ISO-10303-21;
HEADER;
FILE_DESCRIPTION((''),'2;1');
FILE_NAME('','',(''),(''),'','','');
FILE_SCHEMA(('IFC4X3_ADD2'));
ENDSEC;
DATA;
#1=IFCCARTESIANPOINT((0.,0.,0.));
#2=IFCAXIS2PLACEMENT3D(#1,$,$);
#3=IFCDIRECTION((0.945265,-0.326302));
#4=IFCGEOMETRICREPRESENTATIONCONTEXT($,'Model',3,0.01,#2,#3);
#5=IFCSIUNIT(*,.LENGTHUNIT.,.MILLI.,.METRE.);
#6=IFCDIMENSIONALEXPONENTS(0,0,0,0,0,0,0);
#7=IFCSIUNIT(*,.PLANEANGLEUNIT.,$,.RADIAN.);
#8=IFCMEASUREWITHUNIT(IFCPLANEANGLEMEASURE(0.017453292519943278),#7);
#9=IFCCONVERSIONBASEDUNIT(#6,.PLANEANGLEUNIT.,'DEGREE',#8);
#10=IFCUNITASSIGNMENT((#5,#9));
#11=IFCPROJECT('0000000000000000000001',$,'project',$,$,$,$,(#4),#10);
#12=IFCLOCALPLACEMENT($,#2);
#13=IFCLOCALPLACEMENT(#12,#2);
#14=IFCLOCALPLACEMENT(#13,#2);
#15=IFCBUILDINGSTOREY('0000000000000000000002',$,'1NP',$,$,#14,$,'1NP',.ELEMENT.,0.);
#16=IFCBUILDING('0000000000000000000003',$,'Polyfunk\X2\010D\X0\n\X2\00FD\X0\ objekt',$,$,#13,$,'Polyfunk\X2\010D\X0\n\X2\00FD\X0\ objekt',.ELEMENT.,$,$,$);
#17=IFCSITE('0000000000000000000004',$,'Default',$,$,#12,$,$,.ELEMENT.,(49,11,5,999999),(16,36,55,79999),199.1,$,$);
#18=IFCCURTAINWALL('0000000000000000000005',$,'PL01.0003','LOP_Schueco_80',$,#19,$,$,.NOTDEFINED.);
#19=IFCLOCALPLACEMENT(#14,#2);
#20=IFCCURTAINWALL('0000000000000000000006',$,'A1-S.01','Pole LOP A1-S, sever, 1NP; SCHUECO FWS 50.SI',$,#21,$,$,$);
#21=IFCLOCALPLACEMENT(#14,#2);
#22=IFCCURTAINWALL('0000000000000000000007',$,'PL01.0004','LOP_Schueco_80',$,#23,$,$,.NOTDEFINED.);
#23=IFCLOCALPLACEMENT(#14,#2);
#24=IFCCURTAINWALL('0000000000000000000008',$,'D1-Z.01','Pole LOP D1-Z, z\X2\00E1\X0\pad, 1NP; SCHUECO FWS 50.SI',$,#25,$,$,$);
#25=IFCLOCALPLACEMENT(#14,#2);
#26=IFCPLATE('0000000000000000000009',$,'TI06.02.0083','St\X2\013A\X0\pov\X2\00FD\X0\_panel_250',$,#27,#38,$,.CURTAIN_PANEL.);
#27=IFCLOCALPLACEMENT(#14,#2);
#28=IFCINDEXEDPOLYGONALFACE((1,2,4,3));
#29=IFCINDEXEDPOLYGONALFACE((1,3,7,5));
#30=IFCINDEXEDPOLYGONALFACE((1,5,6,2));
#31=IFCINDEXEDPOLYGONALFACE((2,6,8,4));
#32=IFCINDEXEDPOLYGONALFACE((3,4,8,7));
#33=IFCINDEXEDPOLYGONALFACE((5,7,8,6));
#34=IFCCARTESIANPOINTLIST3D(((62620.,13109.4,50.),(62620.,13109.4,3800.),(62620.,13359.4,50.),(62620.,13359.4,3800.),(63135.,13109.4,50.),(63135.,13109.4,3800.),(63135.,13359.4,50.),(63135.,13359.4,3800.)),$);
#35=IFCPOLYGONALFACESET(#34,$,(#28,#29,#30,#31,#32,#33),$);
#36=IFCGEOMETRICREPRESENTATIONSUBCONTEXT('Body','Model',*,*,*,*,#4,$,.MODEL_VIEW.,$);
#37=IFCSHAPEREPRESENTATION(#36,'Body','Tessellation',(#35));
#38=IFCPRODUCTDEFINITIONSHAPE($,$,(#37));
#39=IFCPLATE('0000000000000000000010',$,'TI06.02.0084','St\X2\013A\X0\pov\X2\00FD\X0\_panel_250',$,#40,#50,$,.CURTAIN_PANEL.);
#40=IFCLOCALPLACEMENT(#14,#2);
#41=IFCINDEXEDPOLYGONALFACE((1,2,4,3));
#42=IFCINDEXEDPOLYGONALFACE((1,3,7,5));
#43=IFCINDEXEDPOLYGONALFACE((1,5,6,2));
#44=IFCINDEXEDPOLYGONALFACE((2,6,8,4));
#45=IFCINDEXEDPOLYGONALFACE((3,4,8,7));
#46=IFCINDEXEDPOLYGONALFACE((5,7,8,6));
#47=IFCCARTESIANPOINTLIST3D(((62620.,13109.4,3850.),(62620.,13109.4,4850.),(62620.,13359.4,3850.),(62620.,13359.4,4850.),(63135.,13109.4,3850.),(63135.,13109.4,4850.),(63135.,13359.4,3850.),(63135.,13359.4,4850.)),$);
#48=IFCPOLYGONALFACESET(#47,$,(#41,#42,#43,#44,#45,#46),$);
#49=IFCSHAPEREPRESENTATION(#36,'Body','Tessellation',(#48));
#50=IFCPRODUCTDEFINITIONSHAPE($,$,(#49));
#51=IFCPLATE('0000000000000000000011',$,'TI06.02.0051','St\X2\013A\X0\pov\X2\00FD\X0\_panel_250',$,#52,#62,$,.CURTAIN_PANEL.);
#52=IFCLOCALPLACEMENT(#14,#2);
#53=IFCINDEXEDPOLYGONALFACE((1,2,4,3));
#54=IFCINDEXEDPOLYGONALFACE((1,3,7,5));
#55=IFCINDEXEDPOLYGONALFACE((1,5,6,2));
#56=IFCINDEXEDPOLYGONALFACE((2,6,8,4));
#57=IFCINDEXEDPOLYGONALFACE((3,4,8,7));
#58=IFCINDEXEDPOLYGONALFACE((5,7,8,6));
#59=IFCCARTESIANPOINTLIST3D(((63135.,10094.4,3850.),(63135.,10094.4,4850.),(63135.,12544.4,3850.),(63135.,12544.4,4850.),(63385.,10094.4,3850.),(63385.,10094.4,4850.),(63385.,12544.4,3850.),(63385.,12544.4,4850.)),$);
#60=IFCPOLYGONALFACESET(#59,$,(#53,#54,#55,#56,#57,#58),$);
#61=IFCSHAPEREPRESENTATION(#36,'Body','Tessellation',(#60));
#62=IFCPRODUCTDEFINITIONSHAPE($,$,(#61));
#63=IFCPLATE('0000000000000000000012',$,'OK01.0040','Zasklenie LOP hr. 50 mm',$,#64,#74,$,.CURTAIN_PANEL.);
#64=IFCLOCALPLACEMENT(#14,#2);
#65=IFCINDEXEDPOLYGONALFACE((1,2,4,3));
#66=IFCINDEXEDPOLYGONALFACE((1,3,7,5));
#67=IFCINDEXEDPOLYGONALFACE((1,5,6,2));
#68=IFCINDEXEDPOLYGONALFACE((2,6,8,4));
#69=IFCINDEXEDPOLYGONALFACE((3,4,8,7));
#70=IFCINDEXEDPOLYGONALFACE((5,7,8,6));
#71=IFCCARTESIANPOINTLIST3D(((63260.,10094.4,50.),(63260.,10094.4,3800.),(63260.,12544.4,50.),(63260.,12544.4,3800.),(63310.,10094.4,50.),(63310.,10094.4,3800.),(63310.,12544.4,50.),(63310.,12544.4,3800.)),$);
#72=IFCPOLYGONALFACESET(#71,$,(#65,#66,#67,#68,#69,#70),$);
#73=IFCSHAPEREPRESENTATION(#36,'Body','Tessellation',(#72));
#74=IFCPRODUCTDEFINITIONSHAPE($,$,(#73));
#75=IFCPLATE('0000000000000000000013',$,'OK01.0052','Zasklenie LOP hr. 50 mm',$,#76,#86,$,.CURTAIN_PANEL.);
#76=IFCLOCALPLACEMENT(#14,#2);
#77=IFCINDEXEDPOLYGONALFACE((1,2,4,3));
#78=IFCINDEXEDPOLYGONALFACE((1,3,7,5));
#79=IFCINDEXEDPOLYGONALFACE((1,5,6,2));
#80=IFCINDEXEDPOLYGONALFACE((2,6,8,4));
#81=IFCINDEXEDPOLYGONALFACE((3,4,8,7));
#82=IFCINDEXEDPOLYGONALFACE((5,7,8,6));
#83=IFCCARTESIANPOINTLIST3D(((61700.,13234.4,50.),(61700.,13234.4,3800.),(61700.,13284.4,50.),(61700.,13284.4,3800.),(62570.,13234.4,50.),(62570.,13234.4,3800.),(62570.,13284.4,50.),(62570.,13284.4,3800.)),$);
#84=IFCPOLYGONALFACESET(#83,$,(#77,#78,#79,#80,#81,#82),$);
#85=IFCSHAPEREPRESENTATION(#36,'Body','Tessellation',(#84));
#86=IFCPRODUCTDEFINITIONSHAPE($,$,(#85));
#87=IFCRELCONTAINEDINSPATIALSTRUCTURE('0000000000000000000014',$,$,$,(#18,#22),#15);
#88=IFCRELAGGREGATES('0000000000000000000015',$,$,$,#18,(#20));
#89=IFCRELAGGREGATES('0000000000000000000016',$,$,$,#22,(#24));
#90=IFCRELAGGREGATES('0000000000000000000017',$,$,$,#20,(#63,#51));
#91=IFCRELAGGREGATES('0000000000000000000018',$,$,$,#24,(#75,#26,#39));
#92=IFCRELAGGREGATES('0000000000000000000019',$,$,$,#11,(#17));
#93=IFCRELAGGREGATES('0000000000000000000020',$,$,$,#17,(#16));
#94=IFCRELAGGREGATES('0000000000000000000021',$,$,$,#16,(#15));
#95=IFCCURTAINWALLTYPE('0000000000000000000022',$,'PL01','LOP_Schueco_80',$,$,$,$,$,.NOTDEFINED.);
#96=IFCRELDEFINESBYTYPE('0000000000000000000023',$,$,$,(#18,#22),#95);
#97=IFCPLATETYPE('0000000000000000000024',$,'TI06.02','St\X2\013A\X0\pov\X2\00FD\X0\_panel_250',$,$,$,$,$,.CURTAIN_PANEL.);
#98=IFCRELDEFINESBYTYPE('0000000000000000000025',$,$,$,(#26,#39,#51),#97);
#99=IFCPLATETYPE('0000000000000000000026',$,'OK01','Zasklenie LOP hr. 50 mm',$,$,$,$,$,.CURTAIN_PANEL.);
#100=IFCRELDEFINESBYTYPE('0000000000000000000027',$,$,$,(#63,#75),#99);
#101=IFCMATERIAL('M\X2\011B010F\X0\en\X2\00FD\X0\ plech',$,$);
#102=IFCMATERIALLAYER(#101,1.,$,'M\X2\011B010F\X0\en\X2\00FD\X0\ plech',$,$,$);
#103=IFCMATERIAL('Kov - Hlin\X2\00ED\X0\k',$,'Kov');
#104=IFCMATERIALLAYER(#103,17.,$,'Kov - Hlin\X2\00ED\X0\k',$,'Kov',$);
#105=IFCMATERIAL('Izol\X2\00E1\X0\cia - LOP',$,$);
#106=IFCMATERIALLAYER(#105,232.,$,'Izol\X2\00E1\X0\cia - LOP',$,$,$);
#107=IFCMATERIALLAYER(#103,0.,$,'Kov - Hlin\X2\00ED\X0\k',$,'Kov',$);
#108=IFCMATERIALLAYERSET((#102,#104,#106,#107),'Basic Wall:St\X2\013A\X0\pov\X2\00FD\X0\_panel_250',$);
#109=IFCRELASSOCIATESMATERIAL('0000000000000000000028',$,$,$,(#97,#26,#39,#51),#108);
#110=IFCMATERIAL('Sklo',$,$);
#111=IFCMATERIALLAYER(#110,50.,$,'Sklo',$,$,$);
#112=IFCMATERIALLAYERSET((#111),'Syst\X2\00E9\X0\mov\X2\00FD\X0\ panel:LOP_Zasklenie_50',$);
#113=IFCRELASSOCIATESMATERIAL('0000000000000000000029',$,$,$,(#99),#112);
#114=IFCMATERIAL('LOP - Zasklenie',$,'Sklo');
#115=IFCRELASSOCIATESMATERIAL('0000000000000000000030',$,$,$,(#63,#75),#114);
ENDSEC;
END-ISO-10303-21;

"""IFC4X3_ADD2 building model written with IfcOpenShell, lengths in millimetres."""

from ifc_helpers import new_model, entity, si_unit, converted_unit, direction, frame, frame_2d, origin, place, context, subcontext, project, spatial, rectangle, extrude, source, transform, mapped, material, layer, layer_set, layer_usage, type_object, type_shapes, element, aggregate, save


model = new_model("IFC4X3_ADD2")

# Units and contexts
model_context = context("Model", 3, precision=0.01, world=origin(), true_north=direction((0.945265, -0.326302)))
body_context = subcontext(model_context, "Body", "Model", "MODEL_VIEW")
ifc_project = project(units=[si_unit("LENGTHUNIT", "METRE", prefix="MILLI"), converted_unit("PLANEANGLEUNIT", "DEGREE", entity("IfcPlaneAngleMeasure", 0.017453292519943278), si_unit("PLANEANGLEUNIT", "RADIAN"), dimensions=[0, 0, 0, 0, 0, 0, 0])], contexts=[model_context])

# Site, building, storey
site_placement = place(None, origin())
site = spatial("IfcSite", under=ifc_project, at=site_placement, Name="Default", CompositionType="ELEMENT", RefLatitude=(49, 11, 5, 999999), RefLongitude=(16, 36, 55, 79999), RefElevation=199.1)
building_placement = place(site_placement, origin())
building = spatial("IfcBuilding", under=site, at=building_placement, Name="Polyfunkčný objekt", LongName="Polyfunkčný objekt", CompositionType="ELEMENT")
storey_placement = place(building_placement, origin())
storey = spatial("IfcBuildingStorey", under=building, at=storey_placement, Name="1NP", LongName="1NP", CompositionType="ELEMENT", Elevation=0.0)

# Curtain walls
curtain_wall_type = type_object("IfcCurtainWallType", Name="PL01", Description="LOP_Schueco_80", PredefinedType="NOTDEFINED")
curtain_wall_1_placement = place(storey_placement, origin())
curtain_wall_1 = element("IfcCurtainWall", 1, at=curtain_wall_1_placement, inside=storey, type_object=curtain_wall_type, Name="PL01.0003", Description="LOP_Schueco_80", PredefinedType="NOTDEFINED")
curtain_wall_2 = element("IfcCurtainWall", 2, Name="A1-S.01", Description="Pole LOP A1-S, sever, 1NP; SCHUECO FWS 50.SI")
aggregate(curtain_wall_1, [curtain_wall_2])
curtain_wall_3_placement = place(storey_placement, origin())
curtain_wall_3 = element("IfcCurtainWall", 3, at=curtain_wall_3_placement, inside=storey, type_object=curtain_wall_type, Name="PL01.0004", Description="LOP_Schueco_80", PredefinedType="NOTDEFINED")
curtain_wall_4 = element("IfcCurtainWall", 4, Name="D1-Z.01", Description="Pole LOP D1-Z, západ, 1NP; SCHUECO FWS 50.SI")
aggregate(curtain_wall_3, [curtain_wall_4])

# Plates
ifc_material_1 = material(Name="Měďený plech")
ifc_layer_1 = layer(ifc_material_1, 1.0, Name="Měďený plech")
ifc_material_2 = material(Name="Kov - Hliník", Category="Kov")
ifc_layer_2 = layer(ifc_material_2, 17.0, Name="Kov - Hliník", Category="Kov")
ifc_material_3 = material(Name="Izolácia - LOP")
ifc_layer_3 = layer(ifc_material_3, 232.0, Name="Izolácia - LOP")
ifc_layer_4 = layer(ifc_material_2, 0.0, Name="Kov - Hliník", Category="Kov")
ifc_layer_set_1 = layer_set([ifc_layer_1, ifc_layer_2, ifc_layer_3, ifc_layer_4], Name="Basic Wall:Stĺpový_panel_250")
ifc_layer_usage_1 = layer_usage(ifc_layer_set_1, "AXIS2", "NEGATIVE", 125.0)
plate_type_1 = type_object("IfcPlateType", Name="TI06.02", Description="Stĺpový_panel_250", PredefinedType="CURTAIN_PANEL", material=ifc_layer_set_1)
plate_1_placement = place(storey_placement, frame((62620.0, 13234.4, 50.0)))
plate_1 = element("IfcPlate", 5, at=plate_1_placement, type_object=plate_type_1, material=ifc_layer_usage_1, Name="TI06.02.0083", Description="Stĺpový_panel_250", PredefinedType="CURTAIN_PANEL", context=body_context, shape_type="SweptSolid", body=[
    extrude(rectangle(XDim=250.0, YDim=515.0, at=frame_2d((0.0, 0.0), x_axis=(1.0, 0.0))), frame((257.5, 0.0, 0.0), z_axis=(0.0, 0.0, 1.0), x_axis=(0.0, 1.0, 0.0)), (0.0, 0.0, 1.0), 3750.0),
])
ifc_layer_usage_2 = layer_usage(ifc_layer_set_1, "AXIS2", "NEGATIVE", 125.0)
plate_2_placement = place(storey_placement, frame((62620.0, 13234.4, 3850.0)))
plate_2 = element("IfcPlate", 6, at=plate_2_placement, type_object=plate_type_1, material=ifc_layer_usage_2, Name="TI06.02.0084", Description="Stĺpový_panel_250", PredefinedType="CURTAIN_PANEL", context=body_context, shape_type="SweptSolid", body=[
    extrude(rectangle(XDim=250.0, YDim=515.0, at=frame_2d((0.0, 0.0), x_axis=(1.0, 0.0))), frame((257.5, 0.0, 0.0), z_axis=(0.0, 0.0, 1.0), x_axis=(0.0, 1.0, 0.0)), (0.0, 0.0, 1.0), 1000.0),
])
ifc_layer_usage_3 = layer_usage(ifc_layer_set_1, "AXIS2", "NEGATIVE", 125.0)
plate_3_placement = place(storey_placement, frame((63260.0, 12544.4, 3850.0), z_axis=(0.0, 0.0, 1.0), x_axis=(0.0, -1.0, 0.0)))
plate_3 = element("IfcPlate", 7, at=plate_3_placement, type_object=plate_type_1, material=ifc_layer_usage_3, Name="TI06.02.0051", Description="Stĺpový_panel_250", PredefinedType="CURTAIN_PANEL", context=body_context, shape_type="SweptSolid", body=[
    extrude(rectangle(XDim=250.0, YDim=2450.0, at=frame_2d((0.0, 0.0), x_axis=(1.0, 0.0))), frame((1225.0, 0.0, 0.0), z_axis=(0.0, 0.0, 1.0), x_axis=(0.0, 1.0, 0.0)), (0.0, 0.0, 1.0), 1000.0),
])
ifc_material_4 = material(Name="LOP - Zasklenie", Category="Sklo")
ifc_material_5 = material(Name="Sklo")
ifc_layer_5 = layer(ifc_material_5, 50.0, Name="Sklo")
ifc_layer_set_2 = layer_set([ifc_layer_5], Name="Systémový panel:LOP_Zasklenie_50")
plate_type_2 = type_object("IfcPlateType", Name="OK01", Description="Zasklenie LOP hr. 50 mm", PredefinedType="CURTAIN_PANEL", material=ifc_layer_set_2)
shared_shape_1 = source(origin(), body_context, "Body", "SweptSolid", [
    extrude(rectangle(XDim=3750.0, YDim=2450.0, at=frame_2d((-141.7, 0.0), x_axis=(1.0, 0.0))), frame((0.0, 0.0, 2016.7), z_axis=(0.0, 1.0, 0.0), x_axis=(0.0, 0.0, 1.0)), (0.0, 0.0, 1.0), 50.0),
])
plate_4_placement = place(curtain_wall_1_placement, frame((63260.0, 11319.4, 50.0), z_axis=(0.0, 0.0, 1.0), x_axis=(0.0, -1.0, 0.0)))
plate_4 = element("IfcPlate", 8, at=plate_4_placement, type_object=plate_type_2, material=ifc_material_4, Name="OK01.0040", Description="Zasklenie LOP hr. 50 mm", PredefinedType="CURTAIN_PANEL", context=body_context, shape_type="MappedRepresentation", body=[
    mapped(shared_shape_1, transform((0.0, 0.0, 0.0), scale=1.0)),
])
aggregate(curtain_wall_2, [plate_4, plate_3])
shared_shape_2 = source(origin(), body_context, "Body", "SweptSolid", [
    extrude(rectangle(XDim=3750.0, YDim=870.0, at=frame_2d((-141.7, 0.0), x_axis=(1.0, 0.0))), frame((0.0, 0.0, 2016.7), z_axis=(0.0, 1.0, 0.0), x_axis=(0.0, 0.0, 1.0)), (0.0, 0.0, 1.0), 50.0),
])
type_shapes(plate_type_2, [shared_shape_1, shared_shape_2])
plate_5_placement = place(curtain_wall_3_placement, frame((62135.0, 13234.4, 50.0)))
plate_5 = element("IfcPlate", 9, at=plate_5_placement, type_object=plate_type_2, material=ifc_material_4, Name="OK01.0052", Description="Zasklenie LOP hr. 50 mm", PredefinedType="CURTAIN_PANEL", context=body_context, shape_type="MappedRepresentation", body=[
    mapped(shared_shape_2, transform((0.0, 0.0, 0.0), scale=1.0)),
])
aggregate(curtain_wall_4, [plate_5, plate_1, plate_2])

save(model, "model.ifc")
